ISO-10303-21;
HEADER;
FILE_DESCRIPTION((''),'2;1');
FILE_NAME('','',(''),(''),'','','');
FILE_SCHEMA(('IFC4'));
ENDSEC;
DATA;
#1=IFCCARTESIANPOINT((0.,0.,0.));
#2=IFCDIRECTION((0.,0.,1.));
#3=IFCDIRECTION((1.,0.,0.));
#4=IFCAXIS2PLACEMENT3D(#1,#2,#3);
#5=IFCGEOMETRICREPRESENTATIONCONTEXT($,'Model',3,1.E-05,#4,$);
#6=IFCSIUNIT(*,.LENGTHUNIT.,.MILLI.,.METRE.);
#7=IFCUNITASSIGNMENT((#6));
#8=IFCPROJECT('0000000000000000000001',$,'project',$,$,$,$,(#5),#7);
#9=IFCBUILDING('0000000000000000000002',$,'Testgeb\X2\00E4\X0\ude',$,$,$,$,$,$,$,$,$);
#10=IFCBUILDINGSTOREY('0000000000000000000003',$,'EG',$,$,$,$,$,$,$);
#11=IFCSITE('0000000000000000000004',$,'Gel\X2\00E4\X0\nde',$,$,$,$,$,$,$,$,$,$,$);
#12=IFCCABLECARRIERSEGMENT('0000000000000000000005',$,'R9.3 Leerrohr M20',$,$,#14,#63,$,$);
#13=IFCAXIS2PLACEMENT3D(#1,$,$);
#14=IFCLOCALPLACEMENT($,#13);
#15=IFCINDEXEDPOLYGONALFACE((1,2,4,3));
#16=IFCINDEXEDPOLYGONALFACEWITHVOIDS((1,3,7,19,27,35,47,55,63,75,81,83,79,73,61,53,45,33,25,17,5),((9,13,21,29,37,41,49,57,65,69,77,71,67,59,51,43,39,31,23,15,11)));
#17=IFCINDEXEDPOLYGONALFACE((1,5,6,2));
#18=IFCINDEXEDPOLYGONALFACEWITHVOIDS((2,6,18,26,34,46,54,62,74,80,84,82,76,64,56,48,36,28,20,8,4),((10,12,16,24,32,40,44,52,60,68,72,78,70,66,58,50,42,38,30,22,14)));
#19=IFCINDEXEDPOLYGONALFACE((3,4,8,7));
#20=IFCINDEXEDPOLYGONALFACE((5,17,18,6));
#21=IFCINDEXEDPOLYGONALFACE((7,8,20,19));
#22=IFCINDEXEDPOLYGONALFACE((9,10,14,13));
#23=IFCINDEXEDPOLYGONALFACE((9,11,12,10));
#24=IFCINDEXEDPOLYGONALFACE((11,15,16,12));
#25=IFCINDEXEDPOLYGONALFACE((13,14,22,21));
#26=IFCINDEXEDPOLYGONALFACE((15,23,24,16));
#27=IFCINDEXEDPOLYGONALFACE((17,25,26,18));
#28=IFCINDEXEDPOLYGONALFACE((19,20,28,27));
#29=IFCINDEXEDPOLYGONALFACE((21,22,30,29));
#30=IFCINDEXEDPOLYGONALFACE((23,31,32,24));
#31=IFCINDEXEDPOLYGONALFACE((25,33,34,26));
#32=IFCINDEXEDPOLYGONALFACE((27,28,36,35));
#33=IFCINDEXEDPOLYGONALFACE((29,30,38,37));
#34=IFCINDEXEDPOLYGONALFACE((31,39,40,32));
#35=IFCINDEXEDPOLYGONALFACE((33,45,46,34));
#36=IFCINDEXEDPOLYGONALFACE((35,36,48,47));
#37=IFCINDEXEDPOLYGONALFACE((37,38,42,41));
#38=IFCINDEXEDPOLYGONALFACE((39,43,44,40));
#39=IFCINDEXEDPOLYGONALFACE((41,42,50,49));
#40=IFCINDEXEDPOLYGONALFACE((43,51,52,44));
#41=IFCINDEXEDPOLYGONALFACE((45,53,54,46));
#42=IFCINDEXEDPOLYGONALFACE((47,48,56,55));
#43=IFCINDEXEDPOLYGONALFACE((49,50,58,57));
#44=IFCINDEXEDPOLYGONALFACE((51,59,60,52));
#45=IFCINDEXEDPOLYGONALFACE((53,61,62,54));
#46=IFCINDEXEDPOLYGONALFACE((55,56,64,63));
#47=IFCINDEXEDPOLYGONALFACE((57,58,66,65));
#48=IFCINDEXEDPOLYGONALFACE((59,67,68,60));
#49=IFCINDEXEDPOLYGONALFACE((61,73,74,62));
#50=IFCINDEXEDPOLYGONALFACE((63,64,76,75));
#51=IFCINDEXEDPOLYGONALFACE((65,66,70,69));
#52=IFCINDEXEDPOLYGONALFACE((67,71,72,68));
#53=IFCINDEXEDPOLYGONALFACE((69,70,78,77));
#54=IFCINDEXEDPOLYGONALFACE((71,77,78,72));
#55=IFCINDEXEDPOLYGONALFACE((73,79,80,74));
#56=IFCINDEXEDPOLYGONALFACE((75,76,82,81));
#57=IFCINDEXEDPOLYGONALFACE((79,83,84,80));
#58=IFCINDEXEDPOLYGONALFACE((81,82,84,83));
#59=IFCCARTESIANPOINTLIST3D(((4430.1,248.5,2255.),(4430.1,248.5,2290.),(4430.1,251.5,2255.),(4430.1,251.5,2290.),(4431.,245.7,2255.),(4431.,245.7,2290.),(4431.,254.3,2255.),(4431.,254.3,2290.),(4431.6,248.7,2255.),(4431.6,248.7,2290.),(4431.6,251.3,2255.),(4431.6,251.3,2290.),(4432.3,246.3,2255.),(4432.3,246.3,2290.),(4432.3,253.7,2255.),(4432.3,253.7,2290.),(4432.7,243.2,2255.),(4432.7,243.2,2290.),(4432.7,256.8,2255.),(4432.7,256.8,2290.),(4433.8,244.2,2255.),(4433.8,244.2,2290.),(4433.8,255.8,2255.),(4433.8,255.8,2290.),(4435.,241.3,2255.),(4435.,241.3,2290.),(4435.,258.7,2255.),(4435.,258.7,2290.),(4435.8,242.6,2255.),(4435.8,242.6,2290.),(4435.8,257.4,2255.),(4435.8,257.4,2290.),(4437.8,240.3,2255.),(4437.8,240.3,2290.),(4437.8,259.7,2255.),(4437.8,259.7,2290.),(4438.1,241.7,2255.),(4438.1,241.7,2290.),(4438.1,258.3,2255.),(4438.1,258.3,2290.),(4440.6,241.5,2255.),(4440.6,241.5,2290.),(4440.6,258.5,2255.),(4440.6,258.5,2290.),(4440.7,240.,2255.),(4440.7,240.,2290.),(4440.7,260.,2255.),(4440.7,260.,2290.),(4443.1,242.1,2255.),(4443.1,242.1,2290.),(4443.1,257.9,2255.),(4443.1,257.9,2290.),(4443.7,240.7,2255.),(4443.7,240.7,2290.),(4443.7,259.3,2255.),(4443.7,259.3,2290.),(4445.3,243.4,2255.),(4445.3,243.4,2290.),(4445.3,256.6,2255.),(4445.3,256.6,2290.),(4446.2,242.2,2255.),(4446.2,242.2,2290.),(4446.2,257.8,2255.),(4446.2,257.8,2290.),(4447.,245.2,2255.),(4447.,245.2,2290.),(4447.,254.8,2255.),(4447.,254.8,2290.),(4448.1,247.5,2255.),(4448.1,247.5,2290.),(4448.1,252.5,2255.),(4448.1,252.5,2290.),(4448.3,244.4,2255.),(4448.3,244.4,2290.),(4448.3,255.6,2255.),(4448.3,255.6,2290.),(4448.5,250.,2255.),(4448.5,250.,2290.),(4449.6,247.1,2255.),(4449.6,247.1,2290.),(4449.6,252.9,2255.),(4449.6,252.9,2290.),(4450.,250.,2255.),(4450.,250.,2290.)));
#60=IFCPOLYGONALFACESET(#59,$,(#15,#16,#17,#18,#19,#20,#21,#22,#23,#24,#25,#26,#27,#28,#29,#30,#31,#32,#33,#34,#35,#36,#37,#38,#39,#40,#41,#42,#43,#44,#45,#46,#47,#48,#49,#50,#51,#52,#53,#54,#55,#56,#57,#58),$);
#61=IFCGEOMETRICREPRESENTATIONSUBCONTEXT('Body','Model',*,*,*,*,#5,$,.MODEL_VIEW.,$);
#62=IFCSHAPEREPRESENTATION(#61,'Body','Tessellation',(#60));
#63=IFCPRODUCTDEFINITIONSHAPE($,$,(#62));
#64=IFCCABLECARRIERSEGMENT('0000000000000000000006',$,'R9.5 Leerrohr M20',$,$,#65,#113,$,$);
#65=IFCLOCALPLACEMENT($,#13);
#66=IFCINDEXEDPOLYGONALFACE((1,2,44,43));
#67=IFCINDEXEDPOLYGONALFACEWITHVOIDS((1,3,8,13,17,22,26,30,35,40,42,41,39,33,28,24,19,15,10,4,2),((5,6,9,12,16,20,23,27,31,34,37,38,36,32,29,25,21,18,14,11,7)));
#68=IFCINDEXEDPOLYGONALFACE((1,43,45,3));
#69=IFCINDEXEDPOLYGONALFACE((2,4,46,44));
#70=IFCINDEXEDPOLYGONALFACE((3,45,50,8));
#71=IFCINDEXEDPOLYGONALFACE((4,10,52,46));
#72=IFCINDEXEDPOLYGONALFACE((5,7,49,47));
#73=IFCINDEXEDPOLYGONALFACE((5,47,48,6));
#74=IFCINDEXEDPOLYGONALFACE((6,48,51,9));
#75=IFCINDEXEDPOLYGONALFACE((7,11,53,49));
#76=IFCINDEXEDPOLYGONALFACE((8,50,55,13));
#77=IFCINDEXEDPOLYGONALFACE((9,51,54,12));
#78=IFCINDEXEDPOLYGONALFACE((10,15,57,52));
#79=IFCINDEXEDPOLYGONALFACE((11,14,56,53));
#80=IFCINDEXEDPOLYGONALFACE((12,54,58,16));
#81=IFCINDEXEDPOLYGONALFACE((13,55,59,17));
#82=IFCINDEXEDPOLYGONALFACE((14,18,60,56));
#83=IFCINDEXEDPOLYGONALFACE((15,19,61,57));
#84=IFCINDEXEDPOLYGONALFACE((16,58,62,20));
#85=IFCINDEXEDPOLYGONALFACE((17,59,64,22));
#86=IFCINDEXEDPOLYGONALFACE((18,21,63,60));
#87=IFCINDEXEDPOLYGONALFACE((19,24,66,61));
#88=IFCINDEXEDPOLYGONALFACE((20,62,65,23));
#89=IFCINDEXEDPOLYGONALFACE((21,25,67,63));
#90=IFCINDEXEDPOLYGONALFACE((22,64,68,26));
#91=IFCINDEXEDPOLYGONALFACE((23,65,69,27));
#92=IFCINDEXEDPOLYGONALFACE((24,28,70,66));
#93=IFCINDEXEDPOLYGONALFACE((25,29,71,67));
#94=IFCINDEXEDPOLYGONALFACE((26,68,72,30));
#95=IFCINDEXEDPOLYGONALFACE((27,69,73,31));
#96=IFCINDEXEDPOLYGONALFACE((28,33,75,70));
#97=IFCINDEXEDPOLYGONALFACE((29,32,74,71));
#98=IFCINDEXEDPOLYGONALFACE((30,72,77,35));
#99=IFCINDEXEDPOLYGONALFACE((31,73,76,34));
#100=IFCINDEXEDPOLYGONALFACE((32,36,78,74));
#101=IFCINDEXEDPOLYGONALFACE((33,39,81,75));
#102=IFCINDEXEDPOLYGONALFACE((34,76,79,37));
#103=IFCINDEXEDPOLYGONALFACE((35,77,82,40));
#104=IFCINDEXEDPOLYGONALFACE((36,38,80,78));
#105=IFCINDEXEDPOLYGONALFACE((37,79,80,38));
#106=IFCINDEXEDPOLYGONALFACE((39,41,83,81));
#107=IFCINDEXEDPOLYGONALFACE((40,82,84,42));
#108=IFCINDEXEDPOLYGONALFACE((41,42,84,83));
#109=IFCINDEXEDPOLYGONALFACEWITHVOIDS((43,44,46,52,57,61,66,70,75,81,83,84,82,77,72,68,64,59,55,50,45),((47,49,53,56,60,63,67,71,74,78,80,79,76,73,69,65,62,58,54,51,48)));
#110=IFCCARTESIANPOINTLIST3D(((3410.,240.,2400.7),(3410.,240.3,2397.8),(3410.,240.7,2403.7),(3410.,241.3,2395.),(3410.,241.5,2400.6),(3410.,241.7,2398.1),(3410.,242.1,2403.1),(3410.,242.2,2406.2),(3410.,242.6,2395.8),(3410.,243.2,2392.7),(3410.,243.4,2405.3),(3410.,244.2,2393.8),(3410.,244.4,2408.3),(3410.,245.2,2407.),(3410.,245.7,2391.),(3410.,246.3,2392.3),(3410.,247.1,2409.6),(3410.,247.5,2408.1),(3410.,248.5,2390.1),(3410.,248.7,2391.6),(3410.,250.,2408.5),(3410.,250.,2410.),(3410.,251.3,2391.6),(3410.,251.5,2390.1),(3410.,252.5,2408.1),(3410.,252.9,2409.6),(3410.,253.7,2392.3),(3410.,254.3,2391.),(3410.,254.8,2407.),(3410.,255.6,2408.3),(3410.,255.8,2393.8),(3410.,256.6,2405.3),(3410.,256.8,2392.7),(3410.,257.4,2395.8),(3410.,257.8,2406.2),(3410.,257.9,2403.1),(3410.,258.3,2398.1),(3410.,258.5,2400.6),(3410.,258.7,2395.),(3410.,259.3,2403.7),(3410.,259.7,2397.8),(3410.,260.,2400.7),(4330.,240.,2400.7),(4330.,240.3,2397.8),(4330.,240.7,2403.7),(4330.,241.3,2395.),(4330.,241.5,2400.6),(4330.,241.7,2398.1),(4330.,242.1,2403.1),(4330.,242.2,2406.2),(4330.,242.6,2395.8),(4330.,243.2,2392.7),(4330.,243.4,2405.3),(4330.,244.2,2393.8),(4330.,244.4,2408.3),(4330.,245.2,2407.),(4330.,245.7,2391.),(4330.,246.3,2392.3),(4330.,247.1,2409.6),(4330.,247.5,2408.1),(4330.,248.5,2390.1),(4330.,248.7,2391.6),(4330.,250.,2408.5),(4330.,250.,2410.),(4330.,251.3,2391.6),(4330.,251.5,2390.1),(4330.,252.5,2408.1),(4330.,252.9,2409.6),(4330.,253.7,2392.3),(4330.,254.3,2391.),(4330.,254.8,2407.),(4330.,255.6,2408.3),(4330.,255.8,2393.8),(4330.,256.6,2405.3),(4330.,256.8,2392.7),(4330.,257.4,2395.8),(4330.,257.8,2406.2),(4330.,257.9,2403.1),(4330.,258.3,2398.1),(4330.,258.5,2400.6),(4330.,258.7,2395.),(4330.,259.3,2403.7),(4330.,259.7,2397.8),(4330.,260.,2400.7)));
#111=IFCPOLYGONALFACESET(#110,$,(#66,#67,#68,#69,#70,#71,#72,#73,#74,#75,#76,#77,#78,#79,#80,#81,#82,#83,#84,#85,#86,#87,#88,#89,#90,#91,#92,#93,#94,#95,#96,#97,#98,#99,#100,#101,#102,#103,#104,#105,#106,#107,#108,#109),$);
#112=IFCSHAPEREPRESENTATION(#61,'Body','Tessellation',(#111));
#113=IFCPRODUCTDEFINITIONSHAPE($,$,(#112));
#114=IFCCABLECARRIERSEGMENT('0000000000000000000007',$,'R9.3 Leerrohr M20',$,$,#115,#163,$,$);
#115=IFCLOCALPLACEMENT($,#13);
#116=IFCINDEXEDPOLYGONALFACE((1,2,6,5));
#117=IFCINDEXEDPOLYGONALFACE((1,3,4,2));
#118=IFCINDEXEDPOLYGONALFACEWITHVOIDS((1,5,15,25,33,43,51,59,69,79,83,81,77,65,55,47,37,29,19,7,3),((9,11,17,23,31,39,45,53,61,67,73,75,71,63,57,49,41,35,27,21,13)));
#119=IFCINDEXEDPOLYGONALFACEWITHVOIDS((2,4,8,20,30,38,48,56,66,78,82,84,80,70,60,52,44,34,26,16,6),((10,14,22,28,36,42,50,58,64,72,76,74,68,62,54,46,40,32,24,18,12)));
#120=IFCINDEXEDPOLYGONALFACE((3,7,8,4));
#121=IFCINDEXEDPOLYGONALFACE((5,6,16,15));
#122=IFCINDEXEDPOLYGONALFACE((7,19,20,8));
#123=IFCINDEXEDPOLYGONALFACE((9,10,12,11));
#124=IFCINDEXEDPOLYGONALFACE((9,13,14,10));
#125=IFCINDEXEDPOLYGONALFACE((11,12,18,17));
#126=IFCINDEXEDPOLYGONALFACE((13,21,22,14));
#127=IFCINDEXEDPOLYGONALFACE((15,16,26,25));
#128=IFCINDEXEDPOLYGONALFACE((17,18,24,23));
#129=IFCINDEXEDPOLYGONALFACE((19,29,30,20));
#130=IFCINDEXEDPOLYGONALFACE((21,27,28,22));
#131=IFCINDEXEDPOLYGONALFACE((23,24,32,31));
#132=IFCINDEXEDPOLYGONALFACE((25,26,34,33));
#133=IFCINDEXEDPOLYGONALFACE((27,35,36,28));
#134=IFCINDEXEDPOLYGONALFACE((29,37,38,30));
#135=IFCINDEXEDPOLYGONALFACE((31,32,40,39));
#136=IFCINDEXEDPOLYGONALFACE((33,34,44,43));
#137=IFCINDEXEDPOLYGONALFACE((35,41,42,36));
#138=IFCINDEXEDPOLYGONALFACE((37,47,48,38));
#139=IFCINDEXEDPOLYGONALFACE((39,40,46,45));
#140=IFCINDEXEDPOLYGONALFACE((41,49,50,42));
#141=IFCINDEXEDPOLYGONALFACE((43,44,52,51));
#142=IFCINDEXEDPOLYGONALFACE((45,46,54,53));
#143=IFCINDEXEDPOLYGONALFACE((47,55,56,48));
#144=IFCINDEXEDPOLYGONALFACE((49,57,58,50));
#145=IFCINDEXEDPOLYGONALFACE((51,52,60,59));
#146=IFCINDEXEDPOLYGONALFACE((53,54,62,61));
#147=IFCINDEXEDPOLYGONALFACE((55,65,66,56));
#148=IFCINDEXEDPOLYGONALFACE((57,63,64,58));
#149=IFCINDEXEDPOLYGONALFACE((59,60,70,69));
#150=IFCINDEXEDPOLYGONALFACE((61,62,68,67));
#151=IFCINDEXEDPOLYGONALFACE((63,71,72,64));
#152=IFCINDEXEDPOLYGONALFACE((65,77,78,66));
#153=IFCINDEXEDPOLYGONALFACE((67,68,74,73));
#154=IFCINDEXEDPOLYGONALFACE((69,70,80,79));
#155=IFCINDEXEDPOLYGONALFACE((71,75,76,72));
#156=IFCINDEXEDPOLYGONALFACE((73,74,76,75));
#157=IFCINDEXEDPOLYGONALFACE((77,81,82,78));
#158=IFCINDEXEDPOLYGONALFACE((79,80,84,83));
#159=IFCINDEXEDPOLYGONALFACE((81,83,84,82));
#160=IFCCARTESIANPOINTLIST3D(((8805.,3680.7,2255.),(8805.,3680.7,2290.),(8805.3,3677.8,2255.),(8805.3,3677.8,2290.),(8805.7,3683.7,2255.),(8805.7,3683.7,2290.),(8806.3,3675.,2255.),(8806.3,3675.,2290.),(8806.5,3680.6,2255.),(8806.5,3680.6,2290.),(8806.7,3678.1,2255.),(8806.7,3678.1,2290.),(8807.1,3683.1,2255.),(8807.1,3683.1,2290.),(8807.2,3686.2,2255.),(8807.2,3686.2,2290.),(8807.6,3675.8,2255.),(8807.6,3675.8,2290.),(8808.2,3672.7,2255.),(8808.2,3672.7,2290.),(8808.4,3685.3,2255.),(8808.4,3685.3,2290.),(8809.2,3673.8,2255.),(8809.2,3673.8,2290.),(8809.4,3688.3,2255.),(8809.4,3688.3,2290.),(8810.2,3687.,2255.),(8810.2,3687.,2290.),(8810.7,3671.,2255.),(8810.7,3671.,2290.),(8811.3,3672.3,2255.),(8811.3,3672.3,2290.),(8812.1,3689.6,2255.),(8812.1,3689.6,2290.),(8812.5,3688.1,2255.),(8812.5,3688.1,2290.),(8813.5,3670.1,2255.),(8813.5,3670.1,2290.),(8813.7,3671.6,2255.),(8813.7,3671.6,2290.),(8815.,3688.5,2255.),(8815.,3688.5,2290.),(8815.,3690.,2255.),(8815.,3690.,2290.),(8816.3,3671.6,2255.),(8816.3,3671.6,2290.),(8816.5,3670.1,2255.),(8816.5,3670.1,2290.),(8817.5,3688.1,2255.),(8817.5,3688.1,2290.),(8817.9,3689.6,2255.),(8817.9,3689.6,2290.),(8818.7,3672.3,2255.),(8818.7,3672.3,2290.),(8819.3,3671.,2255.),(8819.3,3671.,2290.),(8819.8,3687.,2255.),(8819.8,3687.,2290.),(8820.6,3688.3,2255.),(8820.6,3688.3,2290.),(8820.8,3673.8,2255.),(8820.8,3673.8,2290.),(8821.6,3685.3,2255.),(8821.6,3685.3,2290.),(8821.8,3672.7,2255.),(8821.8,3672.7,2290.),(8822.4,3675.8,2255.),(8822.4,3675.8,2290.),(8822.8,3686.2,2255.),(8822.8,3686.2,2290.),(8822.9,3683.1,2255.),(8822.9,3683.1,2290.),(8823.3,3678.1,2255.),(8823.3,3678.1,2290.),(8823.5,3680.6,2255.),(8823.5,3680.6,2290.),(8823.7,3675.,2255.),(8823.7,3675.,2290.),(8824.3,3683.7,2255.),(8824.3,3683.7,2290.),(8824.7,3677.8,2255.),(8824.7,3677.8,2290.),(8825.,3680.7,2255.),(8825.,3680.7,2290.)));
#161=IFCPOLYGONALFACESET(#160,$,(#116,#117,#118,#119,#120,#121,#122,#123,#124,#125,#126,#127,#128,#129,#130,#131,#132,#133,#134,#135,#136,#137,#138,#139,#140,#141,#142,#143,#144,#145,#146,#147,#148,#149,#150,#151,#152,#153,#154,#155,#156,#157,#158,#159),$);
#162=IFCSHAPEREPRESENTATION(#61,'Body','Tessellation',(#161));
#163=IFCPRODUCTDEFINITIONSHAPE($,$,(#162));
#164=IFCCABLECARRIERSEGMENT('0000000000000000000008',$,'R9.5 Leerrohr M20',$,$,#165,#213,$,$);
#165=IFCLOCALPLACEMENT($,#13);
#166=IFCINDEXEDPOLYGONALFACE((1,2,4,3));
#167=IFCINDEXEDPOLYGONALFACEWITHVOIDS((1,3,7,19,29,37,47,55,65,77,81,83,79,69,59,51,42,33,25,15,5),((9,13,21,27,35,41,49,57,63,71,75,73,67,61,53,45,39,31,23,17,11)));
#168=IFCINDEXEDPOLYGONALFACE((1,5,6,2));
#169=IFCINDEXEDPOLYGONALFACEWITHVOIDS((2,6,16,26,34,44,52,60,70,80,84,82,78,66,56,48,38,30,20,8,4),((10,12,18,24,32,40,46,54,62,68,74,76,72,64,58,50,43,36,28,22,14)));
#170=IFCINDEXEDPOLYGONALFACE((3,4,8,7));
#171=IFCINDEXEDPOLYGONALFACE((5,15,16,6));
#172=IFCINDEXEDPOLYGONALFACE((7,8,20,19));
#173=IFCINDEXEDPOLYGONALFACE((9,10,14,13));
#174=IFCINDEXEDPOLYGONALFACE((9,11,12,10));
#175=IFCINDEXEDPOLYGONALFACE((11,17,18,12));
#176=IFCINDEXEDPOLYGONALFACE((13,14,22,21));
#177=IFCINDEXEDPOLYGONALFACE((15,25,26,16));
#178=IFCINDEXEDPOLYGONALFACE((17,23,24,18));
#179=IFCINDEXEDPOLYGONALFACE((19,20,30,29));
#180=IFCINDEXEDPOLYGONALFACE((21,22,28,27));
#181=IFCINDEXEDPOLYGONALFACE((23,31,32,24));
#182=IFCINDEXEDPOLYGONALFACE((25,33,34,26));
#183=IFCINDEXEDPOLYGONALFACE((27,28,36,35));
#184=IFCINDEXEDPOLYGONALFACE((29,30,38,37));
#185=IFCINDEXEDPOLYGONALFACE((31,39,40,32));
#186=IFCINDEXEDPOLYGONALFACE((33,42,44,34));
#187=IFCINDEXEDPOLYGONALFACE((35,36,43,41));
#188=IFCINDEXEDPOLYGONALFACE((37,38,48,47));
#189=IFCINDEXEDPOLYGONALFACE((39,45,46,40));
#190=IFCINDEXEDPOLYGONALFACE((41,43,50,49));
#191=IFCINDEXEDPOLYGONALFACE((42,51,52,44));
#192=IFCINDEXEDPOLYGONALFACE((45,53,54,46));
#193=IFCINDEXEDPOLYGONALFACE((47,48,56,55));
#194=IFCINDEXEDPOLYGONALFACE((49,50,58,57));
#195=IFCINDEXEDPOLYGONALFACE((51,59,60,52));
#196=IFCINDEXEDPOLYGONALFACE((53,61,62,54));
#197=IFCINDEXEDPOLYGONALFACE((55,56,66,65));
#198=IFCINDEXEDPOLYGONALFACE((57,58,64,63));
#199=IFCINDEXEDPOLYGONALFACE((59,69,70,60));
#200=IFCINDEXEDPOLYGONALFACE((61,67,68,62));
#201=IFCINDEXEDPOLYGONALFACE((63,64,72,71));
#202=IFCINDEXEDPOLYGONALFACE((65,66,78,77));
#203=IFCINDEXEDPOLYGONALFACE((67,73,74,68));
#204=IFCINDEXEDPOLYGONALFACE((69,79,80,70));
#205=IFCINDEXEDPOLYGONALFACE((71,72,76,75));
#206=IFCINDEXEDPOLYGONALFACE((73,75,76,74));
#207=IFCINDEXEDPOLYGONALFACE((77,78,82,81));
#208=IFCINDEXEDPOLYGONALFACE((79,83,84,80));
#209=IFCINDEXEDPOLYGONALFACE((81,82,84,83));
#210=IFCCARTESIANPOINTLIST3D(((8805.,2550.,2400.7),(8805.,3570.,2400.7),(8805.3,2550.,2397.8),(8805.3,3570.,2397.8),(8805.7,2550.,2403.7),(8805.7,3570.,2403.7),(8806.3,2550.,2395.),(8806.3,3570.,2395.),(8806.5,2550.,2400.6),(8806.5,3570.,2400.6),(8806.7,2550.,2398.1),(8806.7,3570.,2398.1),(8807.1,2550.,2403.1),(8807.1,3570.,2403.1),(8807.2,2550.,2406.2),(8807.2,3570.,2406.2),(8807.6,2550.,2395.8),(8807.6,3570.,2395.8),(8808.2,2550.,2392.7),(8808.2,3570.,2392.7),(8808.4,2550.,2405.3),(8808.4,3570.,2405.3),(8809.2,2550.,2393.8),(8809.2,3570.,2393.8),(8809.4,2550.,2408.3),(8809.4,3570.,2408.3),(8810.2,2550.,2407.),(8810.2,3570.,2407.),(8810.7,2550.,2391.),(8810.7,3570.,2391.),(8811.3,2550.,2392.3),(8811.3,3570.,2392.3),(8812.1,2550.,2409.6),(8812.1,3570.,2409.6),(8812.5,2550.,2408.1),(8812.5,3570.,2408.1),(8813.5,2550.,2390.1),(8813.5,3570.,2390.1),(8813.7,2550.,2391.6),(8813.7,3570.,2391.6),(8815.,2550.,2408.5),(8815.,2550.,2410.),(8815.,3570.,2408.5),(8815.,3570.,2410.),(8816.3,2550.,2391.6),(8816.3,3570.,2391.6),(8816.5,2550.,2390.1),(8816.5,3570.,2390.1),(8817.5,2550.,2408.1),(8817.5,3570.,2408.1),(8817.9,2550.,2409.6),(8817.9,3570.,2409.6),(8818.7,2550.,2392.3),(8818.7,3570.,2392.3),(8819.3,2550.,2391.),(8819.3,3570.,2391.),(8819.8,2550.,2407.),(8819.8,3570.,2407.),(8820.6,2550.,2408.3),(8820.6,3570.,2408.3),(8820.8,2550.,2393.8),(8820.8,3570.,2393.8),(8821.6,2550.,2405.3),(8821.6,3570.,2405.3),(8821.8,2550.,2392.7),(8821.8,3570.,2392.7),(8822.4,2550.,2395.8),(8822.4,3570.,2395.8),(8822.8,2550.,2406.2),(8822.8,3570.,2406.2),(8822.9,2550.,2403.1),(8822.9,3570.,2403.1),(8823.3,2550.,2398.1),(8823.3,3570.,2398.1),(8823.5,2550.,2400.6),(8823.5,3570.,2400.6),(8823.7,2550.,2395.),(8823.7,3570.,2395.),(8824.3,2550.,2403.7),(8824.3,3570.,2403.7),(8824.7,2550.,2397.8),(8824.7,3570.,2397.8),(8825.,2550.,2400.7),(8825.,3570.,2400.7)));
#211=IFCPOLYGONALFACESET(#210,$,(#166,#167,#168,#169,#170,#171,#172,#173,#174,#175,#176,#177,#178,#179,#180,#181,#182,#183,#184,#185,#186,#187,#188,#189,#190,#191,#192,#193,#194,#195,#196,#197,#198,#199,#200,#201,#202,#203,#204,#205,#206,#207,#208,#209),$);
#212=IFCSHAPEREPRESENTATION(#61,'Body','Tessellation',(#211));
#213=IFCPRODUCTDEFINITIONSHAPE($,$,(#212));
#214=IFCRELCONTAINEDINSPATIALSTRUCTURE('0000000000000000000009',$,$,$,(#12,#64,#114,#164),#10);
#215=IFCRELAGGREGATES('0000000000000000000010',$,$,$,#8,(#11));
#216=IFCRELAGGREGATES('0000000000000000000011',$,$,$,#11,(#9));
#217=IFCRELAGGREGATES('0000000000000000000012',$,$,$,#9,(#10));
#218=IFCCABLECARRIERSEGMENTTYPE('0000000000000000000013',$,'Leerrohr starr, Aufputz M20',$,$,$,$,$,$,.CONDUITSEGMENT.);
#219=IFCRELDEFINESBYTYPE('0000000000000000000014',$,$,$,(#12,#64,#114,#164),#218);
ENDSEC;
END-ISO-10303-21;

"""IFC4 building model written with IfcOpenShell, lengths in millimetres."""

from ifc_helpers import new_model, si_unit, frame, origin_with_axes, place, context, subcontext, project, spatial, hollow_circle, extrude, type_object, element, save


model = new_model("IFC4")

# Units and contexts
model_context = context("Model", 3, precision=1e-05, world=origin_with_axes())
body_context = subcontext(model_context, "Body", "Model", "MODEL_VIEW")
ifc_project = project(units=[si_unit("LENGTHUNIT", "METRE", prefix="MILLI")], contexts=[model_context])

# Site, building, storey
site = spatial("IfcSite", under=ifc_project, Name="Gelände")
building = spatial("IfcBuilding", under=site, Name="Testgebäude")
storey = spatial("IfcBuildingStorey", under=building, Name="EG")

# Cable carrier segments
cable_carrier_segment_type_1 = type_object("IfcCableCarrierSegmentType", Name="Leerrohr starr, Aufputz M20", PredefinedType="CONDUITSEGMENT")
cable_carrier_segment_1_placement = place(None, frame((4440.0, 250.0, 2255.0), z_axis=(0.0, 0.0, 1.0), x_axis=(1.0, 0.0, 0.0)))
element("IfcCableCarrierSegment", 1, at=cable_carrier_segment_1_placement, inside=storey, type_object=cable_carrier_segment_type_1, Name="R9.3 Leerrohr M20", context=body_context, shape_type="SweptSolid", body=[
    extrude(hollow_circle(Radius=10.0, WallThickness=1.5), None, (0.0, 0.0, 1.0), 35.0),
])
cable_carrier_segment_2_placement = place(None, frame((4330.0, 250.0, 2400.0), z_axis=(-1.0, 0.0, 0.0), x_axis=(0.0, 0.0, 1.0)))
element("IfcCableCarrierSegment", 2, at=cable_carrier_segment_2_placement, inside=storey, type_object=cable_carrier_segment_type_1, Name="R9.5 Leerrohr M20", context=body_context, shape_type="SweptSolid", body=[
    extrude(hollow_circle(Radius=10.0, WallThickness=1.5), None, (0.0, 0.0, 1.0), 920.0),
])
cable_carrier_segment_3_placement = place(None, frame((8815.0, 3680.0, 2255.0), z_axis=(0.0, 0.0, 1.0), x_axis=(0.0, 1.0, 0.0)))
element("IfcCableCarrierSegment", 3, at=cable_carrier_segment_3_placement, inside=storey, type_object=cable_carrier_segment_type_1, Name="R9.3 Leerrohr M20", context=body_context, shape_type="SweptSolid", body=[
    extrude(hollow_circle(Radius=10.0, WallThickness=1.5), None, (0.0, 0.0, 1.0), 35.0),
])
cable_carrier_segment_4_placement = place(None, frame((8815.0, 3570.0, 2400.0), z_axis=(0.0, -1.0, 0.0), x_axis=(0.0, 0.0, 1.0)))
element("IfcCableCarrierSegment", 4, at=cable_carrier_segment_4_placement, inside=storey, type_object=cable_carrier_segment_type_1, Name="R9.5 Leerrohr M20", context=body_context, shape_type="SweptSolid", body=[
    extrude(hollow_circle(Radius=10.0, WallThickness=1.5), None, (0.0, 0.0, 1.0), 1020.0),
])

save(model, "model.ifc")
